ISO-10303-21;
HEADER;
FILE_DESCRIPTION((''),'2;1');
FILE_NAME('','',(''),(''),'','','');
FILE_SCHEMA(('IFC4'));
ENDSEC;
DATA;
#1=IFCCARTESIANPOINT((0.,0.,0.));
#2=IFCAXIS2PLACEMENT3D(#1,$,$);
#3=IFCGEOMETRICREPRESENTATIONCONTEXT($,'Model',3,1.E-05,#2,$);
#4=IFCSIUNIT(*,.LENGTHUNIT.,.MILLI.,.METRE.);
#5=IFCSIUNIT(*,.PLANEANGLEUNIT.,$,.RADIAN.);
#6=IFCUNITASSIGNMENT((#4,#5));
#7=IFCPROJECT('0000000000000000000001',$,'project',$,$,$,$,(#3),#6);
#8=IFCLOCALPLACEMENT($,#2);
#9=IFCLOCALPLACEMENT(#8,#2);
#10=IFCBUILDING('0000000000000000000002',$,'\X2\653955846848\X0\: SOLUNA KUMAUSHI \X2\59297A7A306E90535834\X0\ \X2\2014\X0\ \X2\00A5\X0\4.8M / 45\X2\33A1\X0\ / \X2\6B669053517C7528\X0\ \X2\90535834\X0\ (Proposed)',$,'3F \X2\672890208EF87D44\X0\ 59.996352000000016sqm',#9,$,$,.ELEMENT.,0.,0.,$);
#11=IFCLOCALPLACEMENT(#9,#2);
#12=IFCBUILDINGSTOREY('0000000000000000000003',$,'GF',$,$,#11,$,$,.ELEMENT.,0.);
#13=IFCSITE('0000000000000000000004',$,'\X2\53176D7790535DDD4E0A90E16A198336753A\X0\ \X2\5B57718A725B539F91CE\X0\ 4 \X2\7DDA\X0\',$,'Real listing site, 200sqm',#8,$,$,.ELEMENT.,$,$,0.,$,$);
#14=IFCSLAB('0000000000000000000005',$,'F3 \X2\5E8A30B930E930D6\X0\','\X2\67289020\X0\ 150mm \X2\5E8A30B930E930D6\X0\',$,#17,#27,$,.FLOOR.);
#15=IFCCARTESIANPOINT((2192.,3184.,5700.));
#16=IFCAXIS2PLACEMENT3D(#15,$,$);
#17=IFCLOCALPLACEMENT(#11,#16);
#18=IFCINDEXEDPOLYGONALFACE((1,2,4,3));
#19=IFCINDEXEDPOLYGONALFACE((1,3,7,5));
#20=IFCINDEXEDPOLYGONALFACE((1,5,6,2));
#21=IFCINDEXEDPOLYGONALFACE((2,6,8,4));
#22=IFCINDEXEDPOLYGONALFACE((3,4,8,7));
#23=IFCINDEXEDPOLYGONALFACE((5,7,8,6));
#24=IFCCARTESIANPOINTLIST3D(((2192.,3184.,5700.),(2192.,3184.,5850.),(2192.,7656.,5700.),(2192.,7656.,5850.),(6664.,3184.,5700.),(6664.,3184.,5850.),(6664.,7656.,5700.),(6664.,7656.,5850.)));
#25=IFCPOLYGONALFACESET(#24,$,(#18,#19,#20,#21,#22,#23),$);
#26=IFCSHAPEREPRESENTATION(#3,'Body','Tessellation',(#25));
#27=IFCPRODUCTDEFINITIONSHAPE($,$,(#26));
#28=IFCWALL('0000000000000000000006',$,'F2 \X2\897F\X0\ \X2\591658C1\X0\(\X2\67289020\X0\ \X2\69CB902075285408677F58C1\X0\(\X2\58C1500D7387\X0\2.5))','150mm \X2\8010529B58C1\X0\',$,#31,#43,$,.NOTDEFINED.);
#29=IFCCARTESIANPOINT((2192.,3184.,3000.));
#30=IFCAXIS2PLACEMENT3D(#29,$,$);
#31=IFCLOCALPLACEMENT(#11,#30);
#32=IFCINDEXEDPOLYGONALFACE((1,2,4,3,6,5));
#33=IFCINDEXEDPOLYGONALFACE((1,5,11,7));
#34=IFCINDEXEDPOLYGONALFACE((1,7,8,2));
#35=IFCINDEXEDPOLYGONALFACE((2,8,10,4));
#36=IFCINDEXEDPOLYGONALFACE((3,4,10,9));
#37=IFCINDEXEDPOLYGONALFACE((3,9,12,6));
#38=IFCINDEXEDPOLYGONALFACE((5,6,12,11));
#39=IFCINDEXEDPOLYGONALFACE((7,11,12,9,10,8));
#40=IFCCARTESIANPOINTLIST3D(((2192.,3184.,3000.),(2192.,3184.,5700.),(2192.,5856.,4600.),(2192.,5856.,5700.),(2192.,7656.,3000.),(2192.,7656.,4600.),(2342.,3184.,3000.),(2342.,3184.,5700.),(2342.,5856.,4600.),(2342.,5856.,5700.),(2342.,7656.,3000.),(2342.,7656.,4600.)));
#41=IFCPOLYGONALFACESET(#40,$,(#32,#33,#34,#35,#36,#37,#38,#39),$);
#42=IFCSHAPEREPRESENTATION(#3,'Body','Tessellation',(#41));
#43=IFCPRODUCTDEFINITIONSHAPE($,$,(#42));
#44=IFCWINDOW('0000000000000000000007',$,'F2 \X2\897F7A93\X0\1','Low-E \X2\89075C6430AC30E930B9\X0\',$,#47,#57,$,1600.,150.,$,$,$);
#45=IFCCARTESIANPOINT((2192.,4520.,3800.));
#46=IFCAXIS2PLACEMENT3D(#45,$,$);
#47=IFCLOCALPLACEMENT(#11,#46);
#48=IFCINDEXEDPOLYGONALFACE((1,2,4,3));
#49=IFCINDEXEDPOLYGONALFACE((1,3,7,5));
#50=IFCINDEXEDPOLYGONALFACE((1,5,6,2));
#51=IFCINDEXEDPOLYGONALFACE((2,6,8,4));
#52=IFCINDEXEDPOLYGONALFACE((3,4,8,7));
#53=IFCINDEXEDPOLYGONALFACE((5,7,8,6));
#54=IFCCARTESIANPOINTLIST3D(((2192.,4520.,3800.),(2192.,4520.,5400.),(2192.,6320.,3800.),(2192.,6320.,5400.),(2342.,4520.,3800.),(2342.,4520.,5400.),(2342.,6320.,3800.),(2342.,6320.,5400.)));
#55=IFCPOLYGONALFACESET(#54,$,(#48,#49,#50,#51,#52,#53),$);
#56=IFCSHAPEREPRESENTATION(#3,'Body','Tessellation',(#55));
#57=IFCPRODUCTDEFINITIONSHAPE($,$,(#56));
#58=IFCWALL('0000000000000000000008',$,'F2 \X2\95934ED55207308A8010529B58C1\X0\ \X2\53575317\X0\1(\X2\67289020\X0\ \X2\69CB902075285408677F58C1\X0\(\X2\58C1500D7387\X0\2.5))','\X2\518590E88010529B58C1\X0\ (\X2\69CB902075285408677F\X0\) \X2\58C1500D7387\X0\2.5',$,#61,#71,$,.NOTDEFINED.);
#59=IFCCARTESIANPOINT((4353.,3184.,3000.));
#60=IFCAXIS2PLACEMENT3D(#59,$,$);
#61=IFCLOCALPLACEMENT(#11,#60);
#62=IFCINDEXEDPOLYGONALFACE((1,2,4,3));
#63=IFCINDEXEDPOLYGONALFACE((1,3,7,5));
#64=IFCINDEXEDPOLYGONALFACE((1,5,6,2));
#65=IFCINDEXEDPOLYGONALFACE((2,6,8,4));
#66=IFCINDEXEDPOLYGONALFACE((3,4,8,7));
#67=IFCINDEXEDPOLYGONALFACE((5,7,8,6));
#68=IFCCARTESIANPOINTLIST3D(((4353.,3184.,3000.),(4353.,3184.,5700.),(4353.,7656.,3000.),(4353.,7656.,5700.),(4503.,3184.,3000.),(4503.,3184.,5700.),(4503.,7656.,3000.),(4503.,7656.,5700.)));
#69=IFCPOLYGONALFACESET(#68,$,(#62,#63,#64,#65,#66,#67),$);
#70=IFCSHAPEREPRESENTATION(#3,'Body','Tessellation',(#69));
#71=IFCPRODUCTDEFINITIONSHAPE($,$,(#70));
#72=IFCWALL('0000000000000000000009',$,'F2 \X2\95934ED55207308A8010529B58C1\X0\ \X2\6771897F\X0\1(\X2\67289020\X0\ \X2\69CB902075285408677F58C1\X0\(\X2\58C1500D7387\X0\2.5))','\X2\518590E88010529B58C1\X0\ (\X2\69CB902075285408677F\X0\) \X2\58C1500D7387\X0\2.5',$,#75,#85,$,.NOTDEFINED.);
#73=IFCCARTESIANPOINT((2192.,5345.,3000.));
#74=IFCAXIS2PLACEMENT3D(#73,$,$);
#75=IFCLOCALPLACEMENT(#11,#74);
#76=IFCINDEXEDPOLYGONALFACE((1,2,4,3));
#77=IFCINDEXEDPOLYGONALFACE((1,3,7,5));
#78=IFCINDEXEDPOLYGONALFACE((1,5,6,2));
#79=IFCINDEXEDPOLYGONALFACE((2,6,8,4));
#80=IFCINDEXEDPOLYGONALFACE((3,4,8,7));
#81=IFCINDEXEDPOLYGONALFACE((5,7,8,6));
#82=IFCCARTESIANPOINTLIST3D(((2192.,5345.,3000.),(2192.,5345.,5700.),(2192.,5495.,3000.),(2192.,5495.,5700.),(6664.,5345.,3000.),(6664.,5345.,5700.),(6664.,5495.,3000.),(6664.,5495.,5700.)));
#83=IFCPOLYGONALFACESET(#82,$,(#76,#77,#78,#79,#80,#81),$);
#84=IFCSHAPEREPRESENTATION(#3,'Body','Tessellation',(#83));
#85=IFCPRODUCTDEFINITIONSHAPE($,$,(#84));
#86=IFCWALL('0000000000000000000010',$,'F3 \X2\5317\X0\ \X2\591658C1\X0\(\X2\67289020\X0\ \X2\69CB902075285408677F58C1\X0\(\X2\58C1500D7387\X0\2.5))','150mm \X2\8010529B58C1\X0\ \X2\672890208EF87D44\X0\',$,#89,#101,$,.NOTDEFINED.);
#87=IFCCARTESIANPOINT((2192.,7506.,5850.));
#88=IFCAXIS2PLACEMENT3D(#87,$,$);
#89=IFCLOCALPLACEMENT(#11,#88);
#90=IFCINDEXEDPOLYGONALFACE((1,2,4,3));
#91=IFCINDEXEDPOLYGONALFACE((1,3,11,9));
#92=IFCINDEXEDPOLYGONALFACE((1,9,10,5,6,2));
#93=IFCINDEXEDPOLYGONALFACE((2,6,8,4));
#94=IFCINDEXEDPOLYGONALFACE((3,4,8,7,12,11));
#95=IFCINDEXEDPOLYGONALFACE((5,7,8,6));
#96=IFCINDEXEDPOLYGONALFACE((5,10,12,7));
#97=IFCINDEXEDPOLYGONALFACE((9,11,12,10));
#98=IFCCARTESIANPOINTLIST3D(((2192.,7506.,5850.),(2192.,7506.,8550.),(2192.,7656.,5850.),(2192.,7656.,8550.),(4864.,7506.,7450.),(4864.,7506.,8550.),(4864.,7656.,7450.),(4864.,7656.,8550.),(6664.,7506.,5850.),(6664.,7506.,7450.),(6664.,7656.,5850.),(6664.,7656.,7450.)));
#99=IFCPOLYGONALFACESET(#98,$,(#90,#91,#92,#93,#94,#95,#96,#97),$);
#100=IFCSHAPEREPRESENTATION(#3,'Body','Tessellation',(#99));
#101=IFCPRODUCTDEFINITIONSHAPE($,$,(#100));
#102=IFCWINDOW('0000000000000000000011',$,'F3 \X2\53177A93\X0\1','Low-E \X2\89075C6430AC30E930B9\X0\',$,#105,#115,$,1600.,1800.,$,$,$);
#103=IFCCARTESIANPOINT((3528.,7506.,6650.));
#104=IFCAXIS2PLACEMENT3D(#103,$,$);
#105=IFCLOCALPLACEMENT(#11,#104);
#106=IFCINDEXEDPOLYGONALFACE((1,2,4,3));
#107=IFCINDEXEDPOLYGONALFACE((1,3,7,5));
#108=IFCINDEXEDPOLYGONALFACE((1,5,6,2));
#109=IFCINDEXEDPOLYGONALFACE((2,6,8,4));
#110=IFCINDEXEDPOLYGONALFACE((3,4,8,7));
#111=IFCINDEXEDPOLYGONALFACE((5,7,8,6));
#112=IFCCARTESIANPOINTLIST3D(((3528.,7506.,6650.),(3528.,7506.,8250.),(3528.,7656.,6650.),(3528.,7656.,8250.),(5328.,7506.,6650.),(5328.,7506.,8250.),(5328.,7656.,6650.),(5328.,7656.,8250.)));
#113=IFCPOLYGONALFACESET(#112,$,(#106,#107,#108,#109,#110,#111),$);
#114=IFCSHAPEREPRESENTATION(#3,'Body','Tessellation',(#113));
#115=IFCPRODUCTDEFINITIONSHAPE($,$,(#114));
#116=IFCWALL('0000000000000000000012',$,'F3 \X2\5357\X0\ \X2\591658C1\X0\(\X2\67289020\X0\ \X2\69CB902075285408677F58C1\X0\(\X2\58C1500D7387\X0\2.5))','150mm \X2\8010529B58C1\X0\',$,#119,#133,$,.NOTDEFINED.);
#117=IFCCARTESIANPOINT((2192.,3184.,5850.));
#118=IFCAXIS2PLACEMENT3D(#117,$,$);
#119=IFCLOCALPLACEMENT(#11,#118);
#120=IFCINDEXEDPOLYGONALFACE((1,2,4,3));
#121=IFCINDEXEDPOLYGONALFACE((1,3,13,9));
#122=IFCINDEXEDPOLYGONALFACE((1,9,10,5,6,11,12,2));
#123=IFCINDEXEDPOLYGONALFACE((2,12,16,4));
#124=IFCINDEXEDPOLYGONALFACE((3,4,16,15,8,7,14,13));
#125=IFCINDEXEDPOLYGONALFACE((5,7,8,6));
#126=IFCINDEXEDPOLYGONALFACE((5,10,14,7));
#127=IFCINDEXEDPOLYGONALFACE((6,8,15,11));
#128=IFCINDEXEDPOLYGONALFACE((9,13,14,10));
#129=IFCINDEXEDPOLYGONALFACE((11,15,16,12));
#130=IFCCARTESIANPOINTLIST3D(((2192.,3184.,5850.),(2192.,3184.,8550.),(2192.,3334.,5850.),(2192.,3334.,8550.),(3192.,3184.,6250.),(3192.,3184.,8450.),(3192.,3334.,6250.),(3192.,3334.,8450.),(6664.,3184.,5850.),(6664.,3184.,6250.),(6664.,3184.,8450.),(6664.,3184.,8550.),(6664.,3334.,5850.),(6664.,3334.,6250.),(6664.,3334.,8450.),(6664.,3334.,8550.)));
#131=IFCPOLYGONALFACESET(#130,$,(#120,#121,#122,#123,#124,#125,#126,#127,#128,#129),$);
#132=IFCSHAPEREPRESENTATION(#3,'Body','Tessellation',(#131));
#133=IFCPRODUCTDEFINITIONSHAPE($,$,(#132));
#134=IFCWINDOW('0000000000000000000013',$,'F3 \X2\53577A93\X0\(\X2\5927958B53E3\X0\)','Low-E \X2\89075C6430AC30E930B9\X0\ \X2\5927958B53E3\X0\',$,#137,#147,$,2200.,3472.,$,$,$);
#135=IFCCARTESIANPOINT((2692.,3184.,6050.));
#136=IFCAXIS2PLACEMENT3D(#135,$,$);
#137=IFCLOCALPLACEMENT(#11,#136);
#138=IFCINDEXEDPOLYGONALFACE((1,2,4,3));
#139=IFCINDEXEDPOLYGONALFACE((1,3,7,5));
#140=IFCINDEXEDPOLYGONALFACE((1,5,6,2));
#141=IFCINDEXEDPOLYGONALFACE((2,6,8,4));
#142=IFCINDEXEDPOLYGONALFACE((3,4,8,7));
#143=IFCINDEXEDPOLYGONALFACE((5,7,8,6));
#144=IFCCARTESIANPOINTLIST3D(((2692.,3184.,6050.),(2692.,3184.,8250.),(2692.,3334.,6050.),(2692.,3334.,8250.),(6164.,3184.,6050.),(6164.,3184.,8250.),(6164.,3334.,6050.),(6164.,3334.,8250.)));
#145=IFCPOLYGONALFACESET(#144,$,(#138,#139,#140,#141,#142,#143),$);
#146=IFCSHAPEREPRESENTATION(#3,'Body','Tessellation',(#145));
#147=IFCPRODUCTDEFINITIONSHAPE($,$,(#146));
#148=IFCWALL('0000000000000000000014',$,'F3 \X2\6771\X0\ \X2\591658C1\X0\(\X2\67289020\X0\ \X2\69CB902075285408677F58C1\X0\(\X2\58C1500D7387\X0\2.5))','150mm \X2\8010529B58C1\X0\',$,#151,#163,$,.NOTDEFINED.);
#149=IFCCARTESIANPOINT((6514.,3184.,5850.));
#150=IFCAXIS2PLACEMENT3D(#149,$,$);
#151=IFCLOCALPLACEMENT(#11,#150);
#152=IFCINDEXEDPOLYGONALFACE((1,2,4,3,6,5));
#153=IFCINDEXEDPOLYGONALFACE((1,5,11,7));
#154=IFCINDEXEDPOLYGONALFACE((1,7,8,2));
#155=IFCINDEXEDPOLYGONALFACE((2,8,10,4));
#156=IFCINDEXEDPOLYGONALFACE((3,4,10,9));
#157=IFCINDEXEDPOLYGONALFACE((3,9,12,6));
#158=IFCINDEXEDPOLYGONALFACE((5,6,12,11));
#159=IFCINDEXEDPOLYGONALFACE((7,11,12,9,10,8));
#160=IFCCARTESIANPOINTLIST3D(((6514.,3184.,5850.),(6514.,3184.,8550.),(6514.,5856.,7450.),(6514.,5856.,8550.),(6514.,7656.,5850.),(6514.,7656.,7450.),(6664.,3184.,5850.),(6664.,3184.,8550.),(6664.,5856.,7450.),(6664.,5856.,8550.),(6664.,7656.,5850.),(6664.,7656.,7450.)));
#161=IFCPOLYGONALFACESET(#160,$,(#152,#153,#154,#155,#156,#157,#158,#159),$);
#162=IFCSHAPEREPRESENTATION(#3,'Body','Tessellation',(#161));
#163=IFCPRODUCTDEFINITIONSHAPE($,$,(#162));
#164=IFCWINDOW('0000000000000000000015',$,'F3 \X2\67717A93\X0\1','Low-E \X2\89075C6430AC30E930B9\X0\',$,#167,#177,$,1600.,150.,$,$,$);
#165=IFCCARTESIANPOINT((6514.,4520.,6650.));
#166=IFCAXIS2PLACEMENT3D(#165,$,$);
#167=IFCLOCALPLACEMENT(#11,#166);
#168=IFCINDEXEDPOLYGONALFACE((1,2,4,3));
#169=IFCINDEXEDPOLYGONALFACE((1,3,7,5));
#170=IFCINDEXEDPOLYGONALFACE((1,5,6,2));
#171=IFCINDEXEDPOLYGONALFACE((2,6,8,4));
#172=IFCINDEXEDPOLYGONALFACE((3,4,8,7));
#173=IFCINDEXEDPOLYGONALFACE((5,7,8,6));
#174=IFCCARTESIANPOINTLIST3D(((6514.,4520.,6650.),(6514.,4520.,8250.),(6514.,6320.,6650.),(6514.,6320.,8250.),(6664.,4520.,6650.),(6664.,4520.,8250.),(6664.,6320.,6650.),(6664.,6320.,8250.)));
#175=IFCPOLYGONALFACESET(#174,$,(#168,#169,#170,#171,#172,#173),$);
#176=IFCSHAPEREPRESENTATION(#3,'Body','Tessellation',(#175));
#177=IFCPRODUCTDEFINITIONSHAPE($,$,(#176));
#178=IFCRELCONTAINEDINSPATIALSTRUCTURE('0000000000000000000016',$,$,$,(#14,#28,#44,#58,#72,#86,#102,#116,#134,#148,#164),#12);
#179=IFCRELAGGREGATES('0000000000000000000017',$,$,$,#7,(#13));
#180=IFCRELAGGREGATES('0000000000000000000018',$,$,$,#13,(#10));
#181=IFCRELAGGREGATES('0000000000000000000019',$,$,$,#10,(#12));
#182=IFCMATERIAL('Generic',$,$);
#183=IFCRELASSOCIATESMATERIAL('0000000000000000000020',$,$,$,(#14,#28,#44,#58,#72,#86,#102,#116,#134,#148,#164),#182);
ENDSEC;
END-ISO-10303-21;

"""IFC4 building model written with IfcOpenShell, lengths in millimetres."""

from ifc_helpers import new_model, si_unit, frame, frame_2d, origin, place, context, project, spatial, rectangle, extrude, material, element, fill, save


model = new_model("IFC4")

# Units and contexts
model_context = context("Model", 3, precision=1e-05, world=origin())
ifc_project = project(units=[si_unit("LENGTHUNIT", "METRE", prefix="MILLI"), si_unit("PLANEANGLEUNIT", "RADIAN")], contexts=[model_context])

# Site, building, storey
site_placement = place(None, origin())
site = spatial("IfcSite", under=ifc_project, at=site_placement, Name="北海道川上郡標茶町 字熊牛原野 4 線", ObjectType="Real listing site, 200sqm", CompositionType="ELEMENT", RefElevation=0.0)
building_placement = place(site_placement, origin())
building = spatial("IfcBuilding", under=site, at=building_placement, Name="改善案: SOLUNA KUMAUSHI 天空の道場 — ¥4.8M / 45㎡ / 武道兼用 道場 (Proposed)", ObjectType="3F 木造軸組 59.996352000000016sqm", CompositionType="ELEMENT", ElevationOfRefHeight=0.0, ElevationOfTerrain=0.0)
storey_placement = place(building_placement, origin())
storey = spatial("IfcBuildingStorey", under=building, at=storey_placement, Name="GF", CompositionType="ELEMENT", Elevation=0.0)

# Slab
ifc_material_1 = material(Name="Generic")
slab_placement = place(storey_placement, frame((2192.0, 3184.0, 5700.0)))
element("IfcSlab", 1, at=slab_placement, inside=storey, material=ifc_material_1, Name="F3 床スラブ", Description="木造 150mm 床スラブ", PredefinedType="FLOOR", context=model_context, shape_type="SweptSolid", body=[
    extrude(rectangle(XDim=4472.0, YDim=4472.0, at=frame_2d((2236.0, 2236.0))), frame((2192.0, 3184.0, 5700.0)), (0.0, 0.0, 1.0), 150.0),
])

# Wall, opening, window
wall_1_placement = place(storey_placement, frame((2192.0, 3184.0, 3000.0)))
wall_1 = element("IfcWall", 2, at=wall_1_placement, inside=storey, material=ifc_material_1, Name="F2 西 外壁(木造 構造用合板壁(壁倍率2.5))", Description="150mm 耐力壁", PredefinedType="NOTDEFINED", context=model_context, shape_type="SweptSolid", body=[
    extrude(rectangle(XDim=150.0, YDim=4472.0, at=frame_2d((75.0, 2236.0))), frame((2192.0, 3184.0, 3000.0)), (0.0, 0.0, 1.0), 2700.0),
])
opening_1_placement = place(storey_placement, frame((2192.0, 4520.0, 3800.0)))
opening_1 = element("IfcOpeningElement", 3, at=opening_1_placement, cuts=wall_1, PredefinedType="NOTDEFINED", context=model_context, shape_type="SweptSolid", body=[
    extrude(rectangle(XDim=150.0, YDim=1800.0, at=frame_2d((75.0, 900.0))), frame((2192.0, 4520.0, 3800.0)), (0.0, 0.0, 1.0), 1600.0),
])
window_1_placement = place(storey_placement, frame((2192.0, 4520.0, 3800.0)))
window_1 = element("IfcWindow", 4, at=window_1_placement, inside=storey, material=ifc_material_1, Name="F2 西窓1", Description="Low-E 複層ガラス", OverallHeight=1600.0, OverallWidth=150.0, context=model_context, shape_type="SweptSolid", body=[
    extrude(rectangle(XDim=150.0, YDim=1800.0, at=frame_2d((75.0, 900.0))), frame((2192.0, 4520.0, 3800.0)), (0.0, 0.0, 1.0), 1600.0),
])
fill(opening_1, window_1)

# Walls
wall_2_placement = place(storey_placement, frame((4353.0, 3184.0, 3000.0)))
element("IfcWall", 5, at=wall_2_placement, inside=storey, material=ifc_material_1, Name="F2 間仕切り耐力壁 南北1(木造 構造用合板壁(壁倍率2.5))", Description="内部耐力壁 (構造用合板) 壁倍率2.5", PredefinedType="NOTDEFINED", context=model_context, shape_type="SweptSolid", body=[
    extrude(rectangle(XDim=150.0, YDim=4472.0, at=frame_2d((75.0, 2236.0))), frame((4353.0, 3184.0, 3000.0)), (0.0, 0.0, 1.0), 2700.0),
])
wall_3_placement = place(storey_placement, frame((2192.0, 5345.0, 3000.0)))
element("IfcWall", 6, at=wall_3_placement, inside=storey, material=ifc_material_1, Name="F2 間仕切り耐力壁 東西1(木造 構造用合板壁(壁倍率2.5))", Description="内部耐力壁 (構造用合板) 壁倍率2.5", PredefinedType="NOTDEFINED", context=model_context, shape_type="SweptSolid", body=[
    extrude(rectangle(XDim=4472.0, YDim=150.0, at=frame_2d((2236.0, 75.0))), frame((2192.0, 5345.0, 3000.0)), (0.0, 0.0, 1.0), 2700.0),
])

# Walls, openings, windows
wall_4_placement = place(storey_placement, frame((2192.0, 7506.0, 5850.0)))
wall_4 = element("IfcWall", 7, at=wall_4_placement, inside=storey, material=ifc_material_1, Name="F3 北 外壁(木造 構造用合板壁(壁倍率2.5))", Description="150mm 耐力壁 木造軸組", PredefinedType="NOTDEFINED", context=model_context, shape_type="SweptSolid", body=[
    extrude(rectangle(XDim=4472.0, YDim=150.0, at=frame_2d((2236.0, 75.0))), frame((2192.0, 7506.0, 5850.0)), (0.0, 0.0, 1.0), 2700.0),
])
opening_2_placement = place(storey_placement, frame((3528.0, 7506.0, 6650.0)))
opening_2 = element("IfcOpeningElement", 8, at=opening_2_placement, cuts=wall_4, PredefinedType="NOTDEFINED", context=model_context, shape_type="SweptSolid", body=[
    extrude(rectangle(XDim=1800.0, YDim=150.0, at=frame_2d((900.0, 75.0))), frame((3528.0, 7506.0, 6650.0)), (0.0, 0.0, 1.0), 1600.0),
])
window_2_placement = place(storey_placement, frame((3528.0, 7506.0, 6650.0)))
window_2 = element("IfcWindow", 9, at=window_2_placement, inside=storey, material=ifc_material_1, Name="F3 北窓1", Description="Low-E 複層ガラス", OverallHeight=1600.0, OverallWidth=1800.0, context=model_context, shape_type="SweptSolid", body=[
    extrude(rectangle(XDim=1800.0, YDim=150.0, at=frame_2d((900.0, 75.0))), frame((3528.0, 7506.0, 6650.0)), (0.0, 0.0, 1.0), 1600.0),
])
fill(opening_2, window_2)
wall_5_placement = place(storey_placement, frame((2192.0, 3184.0, 5850.0)))
wall_5 = element("IfcWall", 10, at=wall_5_placement, inside=storey, material=ifc_material_1, Name="F3 南 外壁(木造 構造用合板壁(壁倍率2.5))", Description="150mm 耐力壁", PredefinedType="NOTDEFINED", context=model_context, shape_type="SweptSolid", body=[
    extrude(rectangle(XDim=4472.0, YDim=150.0, at=frame_2d((2236.0, 75.0))), frame((2192.0, 3184.0, 5850.0)), (0.0, 0.0, 1.0), 2700.0),
])
opening_3_placement = place(storey_placement, frame((2692.0, 3184.0, 6050.0)))
opening_3 = element("IfcOpeningElement", 11, at=opening_3_placement, cuts=wall_5, PredefinedType="NOTDEFINED", context=model_context, shape_type="SweptSolid", body=[
    extrude(rectangle(XDim=3472.0, YDim=150.0, at=frame_2d((1736.0, 75.0))), frame((2692.0, 3184.0, 6050.0)), (0.0, 0.0, 1.0), 2200.0),
])
window_3_placement = place(storey_placement, frame((2692.0, 3184.0, 6050.0)))
window_3 = element("IfcWindow", 12, at=window_3_placement, inside=storey, material=ifc_material_1, Name="F3 南窓(大開口)", Description="Low-E 複層ガラス 大開口", OverallHeight=2200.0, OverallWidth=3472.0, context=model_context, shape_type="SweptSolid", body=[
    extrude(rectangle(XDim=3472.0, YDim=150.0, at=frame_2d((1736.0, 75.0))), frame((2692.0, 3184.0, 6050.0)), (0.0, 0.0, 1.0), 2200.0),
])
fill(opening_3, window_3)
wall_6_placement = place(storey_placement, frame((6514.0, 3184.0, 5850.0)))
wall_6 = element("IfcWall", 13, at=wall_6_placement, inside=storey, material=ifc_material_1, Name="F3 東 外壁(木造 構造用合板壁(壁倍率2.5))", Description="150mm 耐力壁", PredefinedType="NOTDEFINED", context=model_context, shape_type="SweptSolid", body=[
    extrude(rectangle(XDim=150.0, YDim=4472.0, at=frame_2d((75.0, 2236.0))), frame((6514.0, 3184.0, 5850.0)), (0.0, 0.0, 1.0), 2700.0),
])
opening_4_placement = place(storey_placement, frame((6514.0, 4520.0, 6650.0)))
opening_4 = element("IfcOpeningElement", 14, at=opening_4_placement, cuts=wall_6, PredefinedType="NOTDEFINED", context=model_context, shape_type="SweptSolid", body=[
    extrude(rectangle(XDim=150.0, YDim=1800.0, at=frame_2d((75.0, 900.0))), frame((6514.0, 4520.0, 6650.0)), (0.0, 0.0, 1.0), 1600.0),
])
window_4_placement = place(storey_placement, frame((6514.0, 4520.0, 6650.0)))
window_4 = element("IfcWindow", 15, at=window_4_placement, inside=storey, material=ifc_material_1, Name="F3 東窓1", Description="Low-E 複層ガラス", OverallHeight=1600.0, OverallWidth=150.0, context=model_context, shape_type="SweptSolid", body=[
    extrude(rectangle(XDim=150.0, YDim=1800.0, at=frame_2d((75.0, 900.0))), frame((6514.0, 4520.0, 6650.0)), (0.0, 0.0, 1.0), 1600.0),
])
fill(opening_4, window_4)

save(model, "model.ifc")
